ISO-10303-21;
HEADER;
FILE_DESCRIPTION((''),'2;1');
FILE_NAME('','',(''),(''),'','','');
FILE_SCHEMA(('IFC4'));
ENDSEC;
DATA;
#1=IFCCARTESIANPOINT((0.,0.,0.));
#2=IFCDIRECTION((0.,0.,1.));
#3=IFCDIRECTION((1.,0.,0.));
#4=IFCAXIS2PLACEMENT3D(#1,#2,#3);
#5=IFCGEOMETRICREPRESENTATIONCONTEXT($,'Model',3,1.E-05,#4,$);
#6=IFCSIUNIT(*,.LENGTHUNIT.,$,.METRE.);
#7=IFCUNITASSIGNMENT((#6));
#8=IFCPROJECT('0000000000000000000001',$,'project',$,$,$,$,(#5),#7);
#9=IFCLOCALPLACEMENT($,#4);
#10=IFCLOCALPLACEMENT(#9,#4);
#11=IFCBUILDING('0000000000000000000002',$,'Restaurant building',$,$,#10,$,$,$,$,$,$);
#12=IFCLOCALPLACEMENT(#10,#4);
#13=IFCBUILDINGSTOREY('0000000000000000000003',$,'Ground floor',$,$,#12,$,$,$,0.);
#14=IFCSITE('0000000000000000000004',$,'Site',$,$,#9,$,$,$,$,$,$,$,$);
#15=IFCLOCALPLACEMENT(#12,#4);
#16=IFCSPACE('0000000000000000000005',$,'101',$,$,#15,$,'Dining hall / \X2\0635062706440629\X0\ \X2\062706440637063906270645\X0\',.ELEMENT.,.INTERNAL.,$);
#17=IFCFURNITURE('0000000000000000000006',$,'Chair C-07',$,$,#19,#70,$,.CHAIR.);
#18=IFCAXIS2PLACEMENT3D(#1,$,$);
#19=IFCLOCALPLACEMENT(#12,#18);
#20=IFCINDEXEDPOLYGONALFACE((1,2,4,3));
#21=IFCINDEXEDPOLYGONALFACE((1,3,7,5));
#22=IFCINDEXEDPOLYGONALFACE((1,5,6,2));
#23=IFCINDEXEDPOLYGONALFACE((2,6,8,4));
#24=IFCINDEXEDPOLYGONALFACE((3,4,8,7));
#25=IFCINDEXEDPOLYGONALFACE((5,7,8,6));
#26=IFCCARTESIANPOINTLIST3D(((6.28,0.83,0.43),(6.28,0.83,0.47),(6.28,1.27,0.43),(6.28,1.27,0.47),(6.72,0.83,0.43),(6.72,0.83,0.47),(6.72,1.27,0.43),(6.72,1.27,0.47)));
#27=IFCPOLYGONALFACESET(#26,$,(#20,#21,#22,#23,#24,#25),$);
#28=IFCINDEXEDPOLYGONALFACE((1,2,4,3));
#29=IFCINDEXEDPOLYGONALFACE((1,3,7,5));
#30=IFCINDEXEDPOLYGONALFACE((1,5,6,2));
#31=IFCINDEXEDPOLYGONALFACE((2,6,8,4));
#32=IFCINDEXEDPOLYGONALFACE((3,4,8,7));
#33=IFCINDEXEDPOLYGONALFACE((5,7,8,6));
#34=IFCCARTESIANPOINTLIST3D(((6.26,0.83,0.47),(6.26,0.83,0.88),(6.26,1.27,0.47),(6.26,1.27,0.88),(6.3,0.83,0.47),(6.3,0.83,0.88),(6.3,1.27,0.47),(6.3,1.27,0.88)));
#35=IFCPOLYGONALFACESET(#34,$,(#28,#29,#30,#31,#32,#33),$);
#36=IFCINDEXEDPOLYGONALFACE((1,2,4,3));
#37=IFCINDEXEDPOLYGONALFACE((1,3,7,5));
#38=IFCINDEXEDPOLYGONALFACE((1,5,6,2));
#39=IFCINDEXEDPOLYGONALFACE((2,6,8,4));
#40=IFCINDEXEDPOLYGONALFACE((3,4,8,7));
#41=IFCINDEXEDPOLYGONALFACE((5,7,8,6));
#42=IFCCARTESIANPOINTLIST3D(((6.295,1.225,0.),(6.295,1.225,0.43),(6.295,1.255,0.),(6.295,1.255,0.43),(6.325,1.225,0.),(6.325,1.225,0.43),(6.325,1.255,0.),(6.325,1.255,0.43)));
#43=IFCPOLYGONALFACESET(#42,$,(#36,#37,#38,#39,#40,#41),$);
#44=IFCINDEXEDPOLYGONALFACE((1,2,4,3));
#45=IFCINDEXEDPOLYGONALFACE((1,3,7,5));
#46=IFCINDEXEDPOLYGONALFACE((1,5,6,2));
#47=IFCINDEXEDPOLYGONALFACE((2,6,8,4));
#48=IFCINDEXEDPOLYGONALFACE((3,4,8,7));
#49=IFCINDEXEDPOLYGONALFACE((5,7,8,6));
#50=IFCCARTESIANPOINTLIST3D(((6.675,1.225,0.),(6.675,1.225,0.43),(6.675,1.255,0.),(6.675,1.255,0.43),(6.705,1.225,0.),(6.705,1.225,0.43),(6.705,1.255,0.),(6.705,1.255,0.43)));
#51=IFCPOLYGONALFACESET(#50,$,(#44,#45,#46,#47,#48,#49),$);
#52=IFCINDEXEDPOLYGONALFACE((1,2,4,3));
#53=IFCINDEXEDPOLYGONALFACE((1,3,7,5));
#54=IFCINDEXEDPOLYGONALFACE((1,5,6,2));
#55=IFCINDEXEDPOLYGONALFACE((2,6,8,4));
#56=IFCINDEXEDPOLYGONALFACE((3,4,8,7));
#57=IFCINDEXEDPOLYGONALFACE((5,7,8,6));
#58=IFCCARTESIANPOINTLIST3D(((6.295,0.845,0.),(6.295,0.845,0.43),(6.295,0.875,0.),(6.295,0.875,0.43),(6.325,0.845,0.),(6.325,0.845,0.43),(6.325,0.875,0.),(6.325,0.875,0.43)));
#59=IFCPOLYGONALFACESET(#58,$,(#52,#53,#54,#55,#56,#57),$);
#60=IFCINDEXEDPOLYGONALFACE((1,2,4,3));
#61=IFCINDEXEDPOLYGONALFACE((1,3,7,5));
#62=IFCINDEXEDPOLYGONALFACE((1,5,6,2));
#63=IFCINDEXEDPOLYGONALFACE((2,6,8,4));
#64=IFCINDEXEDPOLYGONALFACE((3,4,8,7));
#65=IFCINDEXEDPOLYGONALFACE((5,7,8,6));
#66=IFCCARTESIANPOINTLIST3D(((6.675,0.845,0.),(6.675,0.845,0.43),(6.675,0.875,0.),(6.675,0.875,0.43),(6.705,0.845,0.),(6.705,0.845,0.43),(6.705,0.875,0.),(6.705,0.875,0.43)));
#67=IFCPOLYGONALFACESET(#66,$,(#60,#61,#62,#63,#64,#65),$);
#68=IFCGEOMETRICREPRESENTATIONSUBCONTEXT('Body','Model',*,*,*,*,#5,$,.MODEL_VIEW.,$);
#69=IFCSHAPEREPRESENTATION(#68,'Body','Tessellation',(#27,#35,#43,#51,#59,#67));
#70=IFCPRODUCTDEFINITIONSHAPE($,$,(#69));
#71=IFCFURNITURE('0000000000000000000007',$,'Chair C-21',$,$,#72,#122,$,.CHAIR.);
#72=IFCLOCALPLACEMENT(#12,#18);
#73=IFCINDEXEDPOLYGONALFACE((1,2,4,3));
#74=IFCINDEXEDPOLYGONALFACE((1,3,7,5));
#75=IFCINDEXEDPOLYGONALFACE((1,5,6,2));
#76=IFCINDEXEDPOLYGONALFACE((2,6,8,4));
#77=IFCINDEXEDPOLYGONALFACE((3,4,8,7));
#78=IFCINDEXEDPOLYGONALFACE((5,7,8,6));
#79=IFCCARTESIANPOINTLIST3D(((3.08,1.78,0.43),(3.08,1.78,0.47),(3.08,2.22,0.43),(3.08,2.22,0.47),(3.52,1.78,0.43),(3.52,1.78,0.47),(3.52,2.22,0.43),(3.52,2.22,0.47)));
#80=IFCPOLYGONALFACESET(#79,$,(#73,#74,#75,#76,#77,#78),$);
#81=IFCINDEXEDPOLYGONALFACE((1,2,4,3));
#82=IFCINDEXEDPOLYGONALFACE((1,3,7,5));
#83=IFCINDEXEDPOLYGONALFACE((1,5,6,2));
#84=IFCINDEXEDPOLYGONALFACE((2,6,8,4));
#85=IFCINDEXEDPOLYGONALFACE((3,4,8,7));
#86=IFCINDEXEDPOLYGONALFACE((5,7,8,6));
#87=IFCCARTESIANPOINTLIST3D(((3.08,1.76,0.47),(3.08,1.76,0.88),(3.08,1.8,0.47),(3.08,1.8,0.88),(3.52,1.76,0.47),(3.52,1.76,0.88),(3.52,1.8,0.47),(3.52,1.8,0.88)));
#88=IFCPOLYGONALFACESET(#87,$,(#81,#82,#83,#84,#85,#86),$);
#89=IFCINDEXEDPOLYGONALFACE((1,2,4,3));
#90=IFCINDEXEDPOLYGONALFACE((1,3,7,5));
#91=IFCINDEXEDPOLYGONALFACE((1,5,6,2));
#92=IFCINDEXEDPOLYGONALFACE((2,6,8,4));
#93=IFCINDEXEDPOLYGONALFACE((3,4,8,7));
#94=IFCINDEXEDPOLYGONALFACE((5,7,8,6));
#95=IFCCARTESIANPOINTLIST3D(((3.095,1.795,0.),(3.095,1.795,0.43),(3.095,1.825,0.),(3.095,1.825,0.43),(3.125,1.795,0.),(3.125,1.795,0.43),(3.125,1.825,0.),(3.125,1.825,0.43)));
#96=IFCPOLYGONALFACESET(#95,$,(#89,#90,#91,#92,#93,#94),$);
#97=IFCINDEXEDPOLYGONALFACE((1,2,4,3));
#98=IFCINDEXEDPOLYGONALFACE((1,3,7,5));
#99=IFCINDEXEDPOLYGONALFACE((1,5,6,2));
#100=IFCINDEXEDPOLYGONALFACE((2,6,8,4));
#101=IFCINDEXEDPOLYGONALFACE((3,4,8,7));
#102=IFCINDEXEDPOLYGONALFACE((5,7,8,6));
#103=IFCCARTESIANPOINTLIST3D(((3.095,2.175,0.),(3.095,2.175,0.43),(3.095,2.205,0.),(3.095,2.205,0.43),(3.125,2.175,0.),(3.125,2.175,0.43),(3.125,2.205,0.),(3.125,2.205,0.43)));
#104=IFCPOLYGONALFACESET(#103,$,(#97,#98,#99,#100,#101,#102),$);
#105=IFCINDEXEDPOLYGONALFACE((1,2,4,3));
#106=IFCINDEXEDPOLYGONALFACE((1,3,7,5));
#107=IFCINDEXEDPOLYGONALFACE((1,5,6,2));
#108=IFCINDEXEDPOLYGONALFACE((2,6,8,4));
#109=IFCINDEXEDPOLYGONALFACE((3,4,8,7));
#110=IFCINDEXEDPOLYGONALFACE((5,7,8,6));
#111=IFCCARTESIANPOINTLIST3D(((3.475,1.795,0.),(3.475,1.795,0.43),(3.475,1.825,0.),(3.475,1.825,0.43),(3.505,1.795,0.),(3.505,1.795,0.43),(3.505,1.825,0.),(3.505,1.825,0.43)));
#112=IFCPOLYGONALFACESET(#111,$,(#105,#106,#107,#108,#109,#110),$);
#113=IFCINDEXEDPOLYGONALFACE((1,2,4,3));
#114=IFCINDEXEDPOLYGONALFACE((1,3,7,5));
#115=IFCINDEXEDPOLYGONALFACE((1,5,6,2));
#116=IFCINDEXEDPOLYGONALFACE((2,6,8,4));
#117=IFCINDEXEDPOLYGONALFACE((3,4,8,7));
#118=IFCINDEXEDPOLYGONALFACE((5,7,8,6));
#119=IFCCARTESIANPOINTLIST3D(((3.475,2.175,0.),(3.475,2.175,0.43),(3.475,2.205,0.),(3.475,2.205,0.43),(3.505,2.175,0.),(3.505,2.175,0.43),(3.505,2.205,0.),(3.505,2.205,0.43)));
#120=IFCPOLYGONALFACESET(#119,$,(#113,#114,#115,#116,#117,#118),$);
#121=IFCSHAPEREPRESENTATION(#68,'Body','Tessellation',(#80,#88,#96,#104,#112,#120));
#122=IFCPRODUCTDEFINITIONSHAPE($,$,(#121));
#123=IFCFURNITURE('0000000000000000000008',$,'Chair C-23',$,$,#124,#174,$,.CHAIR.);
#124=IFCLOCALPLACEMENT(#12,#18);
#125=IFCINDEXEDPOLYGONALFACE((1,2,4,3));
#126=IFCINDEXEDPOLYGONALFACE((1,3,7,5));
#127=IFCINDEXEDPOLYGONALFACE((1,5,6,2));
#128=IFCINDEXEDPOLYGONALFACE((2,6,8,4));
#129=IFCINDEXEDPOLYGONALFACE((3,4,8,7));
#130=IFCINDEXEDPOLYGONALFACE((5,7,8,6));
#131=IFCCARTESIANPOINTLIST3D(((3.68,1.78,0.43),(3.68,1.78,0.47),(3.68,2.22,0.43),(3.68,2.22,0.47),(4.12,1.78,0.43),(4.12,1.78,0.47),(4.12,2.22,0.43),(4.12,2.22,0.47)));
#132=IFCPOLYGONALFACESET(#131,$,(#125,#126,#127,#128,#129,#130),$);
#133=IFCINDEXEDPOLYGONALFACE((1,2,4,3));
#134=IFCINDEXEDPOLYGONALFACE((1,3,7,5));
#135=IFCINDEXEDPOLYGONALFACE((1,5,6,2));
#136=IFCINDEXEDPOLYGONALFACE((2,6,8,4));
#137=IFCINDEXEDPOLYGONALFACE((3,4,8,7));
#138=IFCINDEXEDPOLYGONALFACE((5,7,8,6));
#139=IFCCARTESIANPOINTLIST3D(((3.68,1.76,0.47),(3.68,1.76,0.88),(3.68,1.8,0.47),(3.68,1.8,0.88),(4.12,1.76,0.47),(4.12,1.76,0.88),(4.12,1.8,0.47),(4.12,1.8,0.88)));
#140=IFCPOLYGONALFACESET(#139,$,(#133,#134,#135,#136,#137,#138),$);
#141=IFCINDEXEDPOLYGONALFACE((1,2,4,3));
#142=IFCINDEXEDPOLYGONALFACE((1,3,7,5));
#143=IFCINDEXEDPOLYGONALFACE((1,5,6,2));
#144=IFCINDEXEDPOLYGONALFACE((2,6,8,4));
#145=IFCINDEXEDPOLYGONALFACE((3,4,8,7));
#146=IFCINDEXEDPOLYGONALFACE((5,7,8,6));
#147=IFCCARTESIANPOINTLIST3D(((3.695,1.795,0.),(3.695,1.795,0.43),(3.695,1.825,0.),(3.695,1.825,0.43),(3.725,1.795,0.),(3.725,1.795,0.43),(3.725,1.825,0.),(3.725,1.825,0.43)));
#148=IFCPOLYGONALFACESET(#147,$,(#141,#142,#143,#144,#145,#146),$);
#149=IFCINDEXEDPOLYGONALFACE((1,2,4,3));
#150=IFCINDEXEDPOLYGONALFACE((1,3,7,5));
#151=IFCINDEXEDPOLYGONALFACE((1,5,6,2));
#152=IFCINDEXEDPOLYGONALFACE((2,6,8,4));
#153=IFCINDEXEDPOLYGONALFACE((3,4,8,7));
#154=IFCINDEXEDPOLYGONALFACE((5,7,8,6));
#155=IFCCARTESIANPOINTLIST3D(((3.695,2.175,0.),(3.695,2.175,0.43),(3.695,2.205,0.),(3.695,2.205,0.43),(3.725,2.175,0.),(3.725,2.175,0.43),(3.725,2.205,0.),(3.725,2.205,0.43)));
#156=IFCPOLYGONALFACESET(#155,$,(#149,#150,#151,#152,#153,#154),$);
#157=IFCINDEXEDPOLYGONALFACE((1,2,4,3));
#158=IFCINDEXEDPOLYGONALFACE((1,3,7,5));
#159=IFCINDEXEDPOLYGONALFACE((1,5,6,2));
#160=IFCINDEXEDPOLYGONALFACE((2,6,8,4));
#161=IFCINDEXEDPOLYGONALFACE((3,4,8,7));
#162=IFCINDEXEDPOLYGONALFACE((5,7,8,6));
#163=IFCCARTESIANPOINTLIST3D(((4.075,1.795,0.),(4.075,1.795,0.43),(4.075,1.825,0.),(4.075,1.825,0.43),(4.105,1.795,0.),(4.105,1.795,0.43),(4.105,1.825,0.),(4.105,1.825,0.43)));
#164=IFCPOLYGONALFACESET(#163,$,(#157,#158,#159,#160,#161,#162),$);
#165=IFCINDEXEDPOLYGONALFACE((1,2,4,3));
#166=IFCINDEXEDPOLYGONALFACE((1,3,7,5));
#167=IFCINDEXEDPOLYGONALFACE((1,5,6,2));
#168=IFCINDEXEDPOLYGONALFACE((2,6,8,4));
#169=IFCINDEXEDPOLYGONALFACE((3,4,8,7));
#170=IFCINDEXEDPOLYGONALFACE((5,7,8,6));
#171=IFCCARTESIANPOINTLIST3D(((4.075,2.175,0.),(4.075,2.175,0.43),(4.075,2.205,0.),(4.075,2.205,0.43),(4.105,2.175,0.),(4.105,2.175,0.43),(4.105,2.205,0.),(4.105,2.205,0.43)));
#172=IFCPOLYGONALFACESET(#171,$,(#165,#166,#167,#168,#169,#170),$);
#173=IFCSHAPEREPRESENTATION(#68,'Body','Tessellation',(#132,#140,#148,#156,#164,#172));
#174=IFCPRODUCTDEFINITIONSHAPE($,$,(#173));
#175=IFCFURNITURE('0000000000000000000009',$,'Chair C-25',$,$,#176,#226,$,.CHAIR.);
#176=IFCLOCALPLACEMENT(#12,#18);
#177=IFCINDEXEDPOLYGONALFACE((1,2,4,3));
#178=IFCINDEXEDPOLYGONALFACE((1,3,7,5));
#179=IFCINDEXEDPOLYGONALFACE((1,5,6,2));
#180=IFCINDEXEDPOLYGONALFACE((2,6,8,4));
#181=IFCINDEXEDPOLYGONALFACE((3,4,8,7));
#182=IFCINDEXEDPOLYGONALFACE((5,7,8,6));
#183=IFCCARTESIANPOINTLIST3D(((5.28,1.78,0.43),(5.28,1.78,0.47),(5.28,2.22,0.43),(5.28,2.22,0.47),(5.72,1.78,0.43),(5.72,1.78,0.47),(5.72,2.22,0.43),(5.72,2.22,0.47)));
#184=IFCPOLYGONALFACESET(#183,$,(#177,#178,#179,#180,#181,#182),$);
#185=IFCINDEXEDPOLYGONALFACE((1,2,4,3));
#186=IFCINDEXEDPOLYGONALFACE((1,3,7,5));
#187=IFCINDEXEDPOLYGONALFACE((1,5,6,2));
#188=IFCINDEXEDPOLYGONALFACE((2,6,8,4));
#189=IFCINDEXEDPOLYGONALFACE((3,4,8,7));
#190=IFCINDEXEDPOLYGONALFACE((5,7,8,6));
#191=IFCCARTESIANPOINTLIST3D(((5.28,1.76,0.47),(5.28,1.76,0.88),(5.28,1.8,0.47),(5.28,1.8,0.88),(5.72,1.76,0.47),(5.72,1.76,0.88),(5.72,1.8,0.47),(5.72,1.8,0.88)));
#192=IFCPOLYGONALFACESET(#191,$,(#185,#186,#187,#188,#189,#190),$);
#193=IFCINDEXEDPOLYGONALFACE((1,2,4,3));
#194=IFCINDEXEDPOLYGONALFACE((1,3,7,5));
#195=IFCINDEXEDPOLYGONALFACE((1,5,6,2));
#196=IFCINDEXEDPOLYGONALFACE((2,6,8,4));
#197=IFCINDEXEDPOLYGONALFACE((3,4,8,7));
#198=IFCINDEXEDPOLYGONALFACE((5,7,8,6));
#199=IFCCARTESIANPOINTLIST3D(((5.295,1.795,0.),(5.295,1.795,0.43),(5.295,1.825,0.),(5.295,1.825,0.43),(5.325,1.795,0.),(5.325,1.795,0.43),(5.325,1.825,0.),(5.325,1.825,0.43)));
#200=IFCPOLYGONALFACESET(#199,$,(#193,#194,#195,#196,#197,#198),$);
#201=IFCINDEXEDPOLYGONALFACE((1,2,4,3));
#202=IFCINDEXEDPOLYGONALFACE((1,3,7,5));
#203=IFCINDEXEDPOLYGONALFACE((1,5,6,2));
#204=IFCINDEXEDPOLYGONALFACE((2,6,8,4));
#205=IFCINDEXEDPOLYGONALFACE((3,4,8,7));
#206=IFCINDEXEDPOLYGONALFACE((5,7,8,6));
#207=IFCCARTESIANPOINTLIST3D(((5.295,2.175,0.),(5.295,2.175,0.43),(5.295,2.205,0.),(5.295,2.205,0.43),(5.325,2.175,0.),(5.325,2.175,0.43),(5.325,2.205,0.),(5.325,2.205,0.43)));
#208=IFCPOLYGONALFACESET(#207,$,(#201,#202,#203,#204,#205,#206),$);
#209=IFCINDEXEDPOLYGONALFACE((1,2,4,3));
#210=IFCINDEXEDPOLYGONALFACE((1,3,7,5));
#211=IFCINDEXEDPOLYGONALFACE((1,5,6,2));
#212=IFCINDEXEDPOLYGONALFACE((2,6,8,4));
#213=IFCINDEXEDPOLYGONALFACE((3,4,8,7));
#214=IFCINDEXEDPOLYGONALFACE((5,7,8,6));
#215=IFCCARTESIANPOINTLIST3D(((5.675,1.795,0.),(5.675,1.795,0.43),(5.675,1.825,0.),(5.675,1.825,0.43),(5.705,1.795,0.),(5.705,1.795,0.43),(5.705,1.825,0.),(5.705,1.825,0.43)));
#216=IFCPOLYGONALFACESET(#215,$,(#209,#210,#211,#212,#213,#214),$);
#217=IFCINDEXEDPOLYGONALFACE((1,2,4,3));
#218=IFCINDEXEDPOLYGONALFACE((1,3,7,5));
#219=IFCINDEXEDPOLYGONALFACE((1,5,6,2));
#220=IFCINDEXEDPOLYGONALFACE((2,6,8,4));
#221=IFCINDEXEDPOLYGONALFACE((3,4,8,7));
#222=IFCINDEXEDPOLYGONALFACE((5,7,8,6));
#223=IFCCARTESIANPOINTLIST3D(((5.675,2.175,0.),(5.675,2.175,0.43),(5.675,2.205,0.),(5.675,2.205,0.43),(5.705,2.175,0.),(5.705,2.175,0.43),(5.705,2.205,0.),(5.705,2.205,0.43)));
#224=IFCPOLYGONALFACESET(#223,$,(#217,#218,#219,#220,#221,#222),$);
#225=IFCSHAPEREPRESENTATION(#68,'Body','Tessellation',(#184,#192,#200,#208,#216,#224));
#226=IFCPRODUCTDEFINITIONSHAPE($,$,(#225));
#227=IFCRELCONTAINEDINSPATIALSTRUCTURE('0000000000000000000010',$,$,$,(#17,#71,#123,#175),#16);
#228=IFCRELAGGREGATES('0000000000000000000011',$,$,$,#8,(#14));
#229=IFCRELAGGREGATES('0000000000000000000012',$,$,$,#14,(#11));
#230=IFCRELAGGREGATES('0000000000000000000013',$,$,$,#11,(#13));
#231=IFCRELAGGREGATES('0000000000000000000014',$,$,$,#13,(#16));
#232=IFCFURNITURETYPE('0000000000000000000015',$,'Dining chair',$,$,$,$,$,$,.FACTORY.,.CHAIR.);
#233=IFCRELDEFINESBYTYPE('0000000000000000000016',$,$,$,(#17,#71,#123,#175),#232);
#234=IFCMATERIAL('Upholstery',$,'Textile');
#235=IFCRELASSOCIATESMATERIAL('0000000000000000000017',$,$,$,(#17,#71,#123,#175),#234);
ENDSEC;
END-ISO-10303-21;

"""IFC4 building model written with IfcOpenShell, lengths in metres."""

from ifc_helpers import new_model, si_unit, frame, origin, origin_with_axes, origin_2d, place, context, subcontext, project, spatial, rectangle, extrude, source, transform, mapped, material, type_object, type_shapes, element, save


model = new_model("IFC4")

# Units and contexts
model_context = context("Model", 3, precision=1e-05, world=origin_with_axes())
body_context = subcontext(model_context, "Body", "Model", "MODEL_VIEW")
ifc_project = project(units=[si_unit("LENGTHUNIT", "METRE")], contexts=[model_context])

# Site, building, storey, space
site_placement = place(None, origin_with_axes())
site = spatial("IfcSite", under=ifc_project, at=site_placement, Name="Site")
building_placement = place(site_placement, origin_with_axes())
building = spatial("IfcBuilding", under=site, at=building_placement, Name="Restaurant building")
storey_placement = place(building_placement, origin_with_axes())
storey = spatial("IfcBuildingStorey", under=building, at=storey_placement, Name="Ground floor", Elevation=0.0)
space_placement = place(storey_placement, origin_with_axes())
space = spatial("IfcSpace", under=storey, at=space_placement, Name="101", LongName="Dining hall / صالة الطعام", CompositionType="ELEMENT", PredefinedType="INTERNAL")

# Furniture
ifc_material_1 = material(Name="Upholstery", Category="Textile")
furniture_type_1 = type_object("IfcFurnitureType", Name="Dining chair", AssemblyPlace="FACTORY", PredefinedType="CHAIR")
shared_shape_1 = source(origin(), body_context, "Body", "SweptSolid", [
    extrude(rectangle(XDim=0.44, YDim=0.44, at=origin_2d()), frame((0.0, 0.0, 0.43)), (0.0, 0.0, 1.0), 0.04),
    extrude(rectangle(XDim=0.44, YDim=0.04, at=origin_2d()), frame((0.0, -0.22, 0.47)), (0.0, 0.0, 1.0), 0.41),
    extrude(rectangle(XDim=0.03, YDim=0.03, at=origin_2d()), frame((-0.19, -0.19, 0.0)), (0.0, 0.0, 1.0), 0.43),
    extrude(rectangle(XDim=0.03, YDim=0.03, at=origin_2d()), frame((-0.19, 0.19, 0.0)), (0.0, 0.0, 1.0), 0.43),
    extrude(rectangle(XDim=0.03, YDim=0.03, at=origin_2d()), frame((0.19, -0.19, 0.0)), (0.0, 0.0, 1.0), 0.43),
    extrude(rectangle(XDim=0.03, YDim=0.03, at=origin_2d()), frame((0.19, 0.19, 0.0)), (0.0, 0.0, 1.0), 0.43),
])
type_shapes(furniture_type_1, [shared_shape_1])
for number, where, z_axis, x_axis, name in (
    (1, (6.5, 1.05, 0.0), (0.0, 0.0, 1.0), (0.0, -1.0, 0.0), "Chair C-07"),
):
    element("IfcFurniture", number, at=place(storey_placement, frame(where, z_axis=z_axis, x_axis=x_axis)), inside=space, type_object=furniture_type_1, material=ifc_material_1, Name=name, PredefinedType="CHAIR", context=body_context, shape_type="MappedRepresentation", body=[
        mapped(shared_shape_1, transform((0.0, 0.0, 0.0))),
    ])
for number, where, name in (
    (2, (3.3, 2.0, 0.0), "Chair C-21"),
    (3, (3.9, 2.0, 0.0), "Chair C-23"),
    (4, (5.5, 2.0, 0.0), "Chair C-25"),
):
    element("IfcFurniture", number, at=place(storey_placement, frame(where)), inside=space, type_object=furniture_type_1, material=ifc_material_1, Name=name, PredefinedType="CHAIR", context=body_context, shape_type="MappedRepresentation", body=[
        mapped(shared_shape_1, transform((0.0, 0.0, 0.0))),
    ])

save(model, "model.ifc")
